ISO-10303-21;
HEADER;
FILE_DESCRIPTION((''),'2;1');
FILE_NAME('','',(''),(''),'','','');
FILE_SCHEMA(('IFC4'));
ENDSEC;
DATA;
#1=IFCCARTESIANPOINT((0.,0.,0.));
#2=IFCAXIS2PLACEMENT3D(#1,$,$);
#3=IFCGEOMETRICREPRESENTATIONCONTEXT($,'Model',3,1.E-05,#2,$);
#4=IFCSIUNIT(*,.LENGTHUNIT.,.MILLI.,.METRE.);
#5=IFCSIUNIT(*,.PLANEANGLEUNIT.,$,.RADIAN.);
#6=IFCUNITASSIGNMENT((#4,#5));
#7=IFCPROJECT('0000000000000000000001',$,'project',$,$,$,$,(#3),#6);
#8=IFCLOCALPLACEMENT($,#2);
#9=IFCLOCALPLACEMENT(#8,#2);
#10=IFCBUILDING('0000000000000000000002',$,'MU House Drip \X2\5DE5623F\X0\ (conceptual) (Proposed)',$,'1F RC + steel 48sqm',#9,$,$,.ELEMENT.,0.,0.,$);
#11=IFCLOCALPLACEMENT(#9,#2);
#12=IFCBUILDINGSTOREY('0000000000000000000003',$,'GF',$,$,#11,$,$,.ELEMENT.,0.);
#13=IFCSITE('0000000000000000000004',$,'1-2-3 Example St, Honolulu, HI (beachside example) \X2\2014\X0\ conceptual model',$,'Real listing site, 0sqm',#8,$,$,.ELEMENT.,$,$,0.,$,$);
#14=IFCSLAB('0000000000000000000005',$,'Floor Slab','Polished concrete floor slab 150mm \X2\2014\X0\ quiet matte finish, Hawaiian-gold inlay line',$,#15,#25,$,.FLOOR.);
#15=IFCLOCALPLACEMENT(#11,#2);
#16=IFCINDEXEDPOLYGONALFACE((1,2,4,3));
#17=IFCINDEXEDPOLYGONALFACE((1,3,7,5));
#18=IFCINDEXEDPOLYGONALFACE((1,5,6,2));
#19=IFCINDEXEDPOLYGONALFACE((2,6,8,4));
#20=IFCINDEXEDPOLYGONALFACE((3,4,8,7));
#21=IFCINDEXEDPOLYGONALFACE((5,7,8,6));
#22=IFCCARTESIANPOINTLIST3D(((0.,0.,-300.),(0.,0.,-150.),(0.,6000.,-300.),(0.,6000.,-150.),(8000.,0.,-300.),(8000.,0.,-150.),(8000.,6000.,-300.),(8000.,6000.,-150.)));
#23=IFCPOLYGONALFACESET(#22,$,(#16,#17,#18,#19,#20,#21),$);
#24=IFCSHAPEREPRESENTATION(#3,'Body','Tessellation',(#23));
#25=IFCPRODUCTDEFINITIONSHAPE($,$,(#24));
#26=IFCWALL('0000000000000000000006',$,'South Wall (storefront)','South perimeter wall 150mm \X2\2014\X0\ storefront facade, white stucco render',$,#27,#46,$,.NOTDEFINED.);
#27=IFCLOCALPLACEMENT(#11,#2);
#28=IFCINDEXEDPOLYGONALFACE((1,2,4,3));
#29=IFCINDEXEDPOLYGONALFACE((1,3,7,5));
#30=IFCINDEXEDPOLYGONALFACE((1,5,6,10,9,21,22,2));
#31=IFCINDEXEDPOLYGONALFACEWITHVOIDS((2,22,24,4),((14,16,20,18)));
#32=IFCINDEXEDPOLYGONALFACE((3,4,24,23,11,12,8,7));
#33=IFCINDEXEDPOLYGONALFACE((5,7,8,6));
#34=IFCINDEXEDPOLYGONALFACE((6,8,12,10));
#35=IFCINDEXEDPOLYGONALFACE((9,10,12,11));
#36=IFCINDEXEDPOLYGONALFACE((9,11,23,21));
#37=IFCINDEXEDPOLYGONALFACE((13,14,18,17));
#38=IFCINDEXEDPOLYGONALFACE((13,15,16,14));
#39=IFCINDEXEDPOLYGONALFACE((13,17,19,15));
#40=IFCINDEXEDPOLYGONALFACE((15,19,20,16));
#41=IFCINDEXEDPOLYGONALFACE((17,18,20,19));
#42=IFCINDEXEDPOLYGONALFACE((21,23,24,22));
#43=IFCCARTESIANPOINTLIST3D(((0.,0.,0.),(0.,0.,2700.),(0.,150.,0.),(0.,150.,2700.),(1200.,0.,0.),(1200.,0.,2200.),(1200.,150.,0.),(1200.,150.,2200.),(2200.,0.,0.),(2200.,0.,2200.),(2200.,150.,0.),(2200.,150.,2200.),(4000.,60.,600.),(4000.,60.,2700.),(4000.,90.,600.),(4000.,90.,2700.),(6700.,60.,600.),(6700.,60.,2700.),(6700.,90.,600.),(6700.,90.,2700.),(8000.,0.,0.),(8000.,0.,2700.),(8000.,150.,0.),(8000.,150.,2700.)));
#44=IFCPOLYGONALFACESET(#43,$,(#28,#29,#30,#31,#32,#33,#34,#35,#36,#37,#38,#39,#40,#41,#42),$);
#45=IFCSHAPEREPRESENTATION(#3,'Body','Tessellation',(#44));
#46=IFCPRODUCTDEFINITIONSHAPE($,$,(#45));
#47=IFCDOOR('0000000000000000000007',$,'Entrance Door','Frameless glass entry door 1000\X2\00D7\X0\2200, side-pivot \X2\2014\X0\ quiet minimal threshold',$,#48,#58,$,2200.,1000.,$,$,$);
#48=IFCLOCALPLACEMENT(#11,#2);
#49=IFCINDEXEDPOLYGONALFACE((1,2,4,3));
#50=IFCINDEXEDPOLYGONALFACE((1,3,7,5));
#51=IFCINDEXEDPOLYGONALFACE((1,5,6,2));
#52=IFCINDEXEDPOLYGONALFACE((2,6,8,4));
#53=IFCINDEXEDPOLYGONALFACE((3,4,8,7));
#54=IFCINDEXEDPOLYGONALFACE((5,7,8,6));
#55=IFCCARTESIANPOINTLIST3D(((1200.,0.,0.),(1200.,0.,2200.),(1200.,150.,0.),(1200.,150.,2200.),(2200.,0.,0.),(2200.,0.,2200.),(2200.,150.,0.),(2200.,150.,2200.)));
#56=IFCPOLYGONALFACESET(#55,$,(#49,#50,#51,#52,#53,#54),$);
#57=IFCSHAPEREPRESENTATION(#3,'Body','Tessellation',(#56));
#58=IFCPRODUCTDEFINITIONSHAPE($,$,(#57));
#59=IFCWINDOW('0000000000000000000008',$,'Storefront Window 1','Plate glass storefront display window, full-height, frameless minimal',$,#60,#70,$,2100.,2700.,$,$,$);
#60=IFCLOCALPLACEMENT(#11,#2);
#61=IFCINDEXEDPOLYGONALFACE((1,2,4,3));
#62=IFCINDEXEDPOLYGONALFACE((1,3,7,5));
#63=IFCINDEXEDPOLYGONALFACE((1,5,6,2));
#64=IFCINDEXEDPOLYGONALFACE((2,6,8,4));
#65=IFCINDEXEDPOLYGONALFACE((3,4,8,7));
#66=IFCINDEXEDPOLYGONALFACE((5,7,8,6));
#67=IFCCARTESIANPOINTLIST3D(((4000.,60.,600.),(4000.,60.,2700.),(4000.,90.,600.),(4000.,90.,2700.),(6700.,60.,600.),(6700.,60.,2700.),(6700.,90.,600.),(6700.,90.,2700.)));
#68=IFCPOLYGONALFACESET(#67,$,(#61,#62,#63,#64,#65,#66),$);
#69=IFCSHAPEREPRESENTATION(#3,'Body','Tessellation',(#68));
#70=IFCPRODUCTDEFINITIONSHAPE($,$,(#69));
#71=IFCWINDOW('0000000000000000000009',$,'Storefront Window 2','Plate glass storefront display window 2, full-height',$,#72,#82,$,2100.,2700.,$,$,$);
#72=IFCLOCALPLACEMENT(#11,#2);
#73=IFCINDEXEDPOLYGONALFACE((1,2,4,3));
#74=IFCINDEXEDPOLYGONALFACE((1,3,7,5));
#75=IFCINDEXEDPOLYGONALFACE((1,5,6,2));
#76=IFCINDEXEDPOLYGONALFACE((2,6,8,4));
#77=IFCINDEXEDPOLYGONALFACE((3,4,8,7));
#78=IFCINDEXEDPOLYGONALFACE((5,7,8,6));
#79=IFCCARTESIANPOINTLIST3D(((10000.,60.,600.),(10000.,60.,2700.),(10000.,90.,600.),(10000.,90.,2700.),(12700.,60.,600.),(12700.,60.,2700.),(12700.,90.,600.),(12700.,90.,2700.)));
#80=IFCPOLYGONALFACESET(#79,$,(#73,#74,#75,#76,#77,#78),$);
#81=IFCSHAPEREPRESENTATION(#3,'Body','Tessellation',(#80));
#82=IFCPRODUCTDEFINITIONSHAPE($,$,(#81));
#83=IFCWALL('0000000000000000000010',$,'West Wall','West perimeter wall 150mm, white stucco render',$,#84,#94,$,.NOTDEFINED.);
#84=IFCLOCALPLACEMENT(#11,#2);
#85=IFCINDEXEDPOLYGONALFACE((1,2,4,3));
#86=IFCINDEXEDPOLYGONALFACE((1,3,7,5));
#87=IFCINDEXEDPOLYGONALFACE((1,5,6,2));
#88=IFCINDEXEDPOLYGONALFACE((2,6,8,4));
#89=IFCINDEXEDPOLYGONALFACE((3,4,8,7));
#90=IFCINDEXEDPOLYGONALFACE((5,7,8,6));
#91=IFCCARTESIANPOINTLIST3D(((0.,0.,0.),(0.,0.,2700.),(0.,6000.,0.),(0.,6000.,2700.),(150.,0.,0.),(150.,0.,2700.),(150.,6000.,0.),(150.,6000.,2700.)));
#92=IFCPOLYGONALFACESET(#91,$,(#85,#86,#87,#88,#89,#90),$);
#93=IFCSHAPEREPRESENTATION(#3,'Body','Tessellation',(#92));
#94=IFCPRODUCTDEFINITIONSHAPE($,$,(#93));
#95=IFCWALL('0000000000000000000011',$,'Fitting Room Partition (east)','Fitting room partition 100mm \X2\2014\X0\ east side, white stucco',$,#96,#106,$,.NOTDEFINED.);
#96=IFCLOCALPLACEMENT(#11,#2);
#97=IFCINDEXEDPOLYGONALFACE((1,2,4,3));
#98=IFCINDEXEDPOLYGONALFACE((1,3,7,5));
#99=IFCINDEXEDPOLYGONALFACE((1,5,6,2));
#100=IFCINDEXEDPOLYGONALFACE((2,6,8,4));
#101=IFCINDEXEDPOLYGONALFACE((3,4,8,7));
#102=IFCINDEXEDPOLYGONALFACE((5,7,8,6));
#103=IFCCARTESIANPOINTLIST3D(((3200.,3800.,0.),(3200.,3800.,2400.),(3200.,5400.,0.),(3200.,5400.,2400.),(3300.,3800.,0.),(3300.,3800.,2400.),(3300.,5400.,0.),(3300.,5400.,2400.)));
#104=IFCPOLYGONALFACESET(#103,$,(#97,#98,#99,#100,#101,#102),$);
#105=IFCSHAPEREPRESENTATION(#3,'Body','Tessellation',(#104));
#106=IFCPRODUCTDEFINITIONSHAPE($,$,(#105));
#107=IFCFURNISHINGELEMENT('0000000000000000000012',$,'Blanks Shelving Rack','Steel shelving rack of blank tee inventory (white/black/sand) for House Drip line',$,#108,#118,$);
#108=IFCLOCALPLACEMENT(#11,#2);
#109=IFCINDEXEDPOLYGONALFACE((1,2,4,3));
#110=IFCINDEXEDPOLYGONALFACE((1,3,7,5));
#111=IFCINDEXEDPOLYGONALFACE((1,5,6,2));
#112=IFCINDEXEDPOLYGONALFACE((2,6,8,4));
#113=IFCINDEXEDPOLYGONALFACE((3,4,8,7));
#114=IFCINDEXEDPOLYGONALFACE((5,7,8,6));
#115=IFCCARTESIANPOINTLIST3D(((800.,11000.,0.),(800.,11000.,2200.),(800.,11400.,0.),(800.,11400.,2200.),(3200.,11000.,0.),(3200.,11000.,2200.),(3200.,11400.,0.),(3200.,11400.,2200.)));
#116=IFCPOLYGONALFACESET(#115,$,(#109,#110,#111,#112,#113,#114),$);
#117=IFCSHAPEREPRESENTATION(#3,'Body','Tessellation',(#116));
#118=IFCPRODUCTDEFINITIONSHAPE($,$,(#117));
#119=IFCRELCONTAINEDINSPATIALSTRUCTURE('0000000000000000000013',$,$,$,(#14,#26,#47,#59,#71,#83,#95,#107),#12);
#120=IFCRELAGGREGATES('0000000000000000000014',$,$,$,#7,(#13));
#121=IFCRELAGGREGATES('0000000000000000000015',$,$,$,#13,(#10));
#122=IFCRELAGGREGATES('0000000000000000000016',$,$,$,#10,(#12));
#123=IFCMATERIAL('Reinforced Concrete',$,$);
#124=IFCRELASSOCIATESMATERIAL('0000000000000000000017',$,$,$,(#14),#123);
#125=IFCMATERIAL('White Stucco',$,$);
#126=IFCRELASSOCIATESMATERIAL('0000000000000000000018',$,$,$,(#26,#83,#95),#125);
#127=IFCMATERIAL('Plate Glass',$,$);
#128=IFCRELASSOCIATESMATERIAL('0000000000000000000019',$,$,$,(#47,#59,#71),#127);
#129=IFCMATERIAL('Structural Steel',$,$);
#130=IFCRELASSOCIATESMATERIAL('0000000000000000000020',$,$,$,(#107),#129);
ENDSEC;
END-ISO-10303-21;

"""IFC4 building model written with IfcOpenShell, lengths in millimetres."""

from ifc_helpers import new_model, si_unit, frame, frame_2d, origin, place, context, project, spatial, rectangle, extrude, material, element, fill, save


model = new_model("IFC4")

# Units and contexts
model_context = context("Model", 3, precision=1e-05, world=origin())
ifc_project = project(units=[si_unit("LENGTHUNIT", "METRE", prefix="MILLI"), si_unit("PLANEANGLEUNIT", "RADIAN")], contexts=[model_context])

# Site, building, storey
site_placement = place(None, origin())
site = spatial("IfcSite", under=ifc_project, at=site_placement, Name="1-2-3 Example St, Honolulu, HI (beachside example) — conceptual model", ObjectType="Real listing site, 0sqm", CompositionType="ELEMENT", RefElevation=0.0)
building_placement = place(site_placement, origin())
building = spatial("IfcBuilding", under=site, at=building_placement, Name="MU House Drip 工房 (conceptual) (Proposed)", ObjectType="1F RC + steel 48sqm", CompositionType="ELEMENT", ElevationOfRefHeight=0.0, ElevationOfTerrain=0.0)
storey_placement = place(building_placement, origin())
storey = spatial("IfcBuildingStorey", under=building, at=storey_placement, Name="GF", CompositionType="ELEMENT", Elevation=0.0)

# Slab
ifc_material_1 = material(Name="Reinforced Concrete")
slab_1_placement = place(storey_placement, frame((0.0, 0.0, -150.0)))
element("IfcSlab", 1, at=slab_1_placement, inside=storey, material=ifc_material_1, Name="Floor Slab", Description="Polished concrete floor slab 150mm — quiet matte finish, Hawaiian-gold inlay line", PredefinedType="FLOOR", context=model_context, shape_type="SweptSolid", body=[
    extrude(rectangle(XDim=8000.0, YDim=6000.0, at=frame_2d((4000.0, 3000.0))), frame((0.0, 0.0, -150.0)), (0.0, 0.0, 1.0), 150.0),
])

# Wall, openings, door, windows
ifc_material_2 = material(Name="White Stucco")
wall_1_placement = place(storey_placement, origin())
wall_1 = element("IfcWall", 2, at=wall_1_placement, inside=storey, material=ifc_material_2, Name="South Wall (storefront)", Description="South perimeter wall 150mm — storefront facade, white stucco render", PredefinedType="NOTDEFINED", context=model_context, shape_type="SweptSolid", body=[
    extrude(rectangle(XDim=8000.0, YDim=150.0, at=frame_2d((4000.0, 75.0))), origin(), (0.0, 0.0, 1.0), 2700.0),
])
opening_1_placement = place(storey_placement, frame((600.0, 0.0, 0.0)))
opening_1 = element("IfcOpeningElement", 3, at=opening_1_placement, cuts=wall_1, PredefinedType="NOTDEFINED", context=model_context, shape_type="SweptSolid", body=[
    extrude(rectangle(XDim=1000.0, YDim=150.0, at=frame_2d((500.0, 75.0))), frame((600.0, 0.0, 0.0)), (0.0, 0.0, 1.0), 2200.0),
])
opening_2_placement = place(storey_placement, frame((2000.0, 30.0, 300.0)))
opening_2 = element("IfcOpeningElement", 4, at=opening_2_placement, cuts=wall_1, PredefinedType="NOTDEFINED", context=model_context, shape_type="SweptSolid", body=[
    extrude(rectangle(XDim=2700.0, YDim=30.0, at=frame_2d((1350.0, 15.0))), frame((2000.0, 30.0, 300.0)), (0.0, 0.0, 1.0), 2100.0),
])
opening_3_placement = place(storey_placement, frame((5000.0, 30.0, 300.0)))
opening_3 = element("IfcOpeningElement", 5, at=opening_3_placement, cuts=wall_1, PredefinedType="NOTDEFINED", context=model_context, shape_type="SweptSolid", body=[
    extrude(rectangle(XDim=2700.0, YDim=30.0, at=frame_2d((1350.0, 15.0))), frame((5000.0, 30.0, 300.0)), (0.0, 0.0, 1.0), 2100.0),
])
ifc_material_3 = material(Name="Plate Glass")
door_1_placement = place(storey_placement, frame((600.0, 0.0, 0.0)))
door_1 = element("IfcDoor", 6, at=door_1_placement, inside=storey, material=ifc_material_3, Name="Entrance Door", Description="Frameless glass entry door 1000×2200, side-pivot — quiet minimal threshold", OverallHeight=2200.0, OverallWidth=1000.0, context=model_context, shape_type="SweptSolid", body=[
    extrude(rectangle(XDim=1000.0, YDim=150.0, at=frame_2d((500.0, 75.0))), frame((600.0, 0.0, 0.0)), (0.0, 0.0, 1.0), 2200.0),
])
fill(opening_1, door_1)
window_1_placement = place(storey_placement, frame((2000.0, 30.0, 300.0)))
window_1 = element("IfcWindow", 7, at=window_1_placement, inside=storey, material=ifc_material_3, Name="Storefront Window 1", Description="Plate glass storefront display window, full-height, frameless minimal", OverallHeight=2100.0, OverallWidth=2700.0, context=model_context, shape_type="SweptSolid", body=[
    extrude(rectangle(XDim=2700.0, YDim=30.0, at=frame_2d((1350.0, 15.0))), frame((2000.0, 30.0, 300.0)), (0.0, 0.0, 1.0), 2100.0),
])
fill(opening_2, window_1)
window_2_placement = place(storey_placement, frame((5000.0, 30.0, 300.0)))
window_2 = element("IfcWindow", 8, at=window_2_placement, inside=storey, material=ifc_material_3, Name="Storefront Window 2", Description="Plate glass storefront display window 2, full-height", OverallHeight=2100.0, OverallWidth=2700.0, context=model_context, shape_type="SweptSolid", body=[
    extrude(rectangle(XDim=2700.0, YDim=30.0, at=frame_2d((1350.0, 15.0))), frame((5000.0, 30.0, 300.0)), (0.0, 0.0, 1.0), 2100.0),
])
fill(opening_3, window_2)

# Walls
wall_2_placement = place(storey_placement, origin())
element("IfcWall", 9, at=wall_2_placement, inside=storey, material=ifc_material_2, Name="West Wall", Description="West perimeter wall 150mm, white stucco render", PredefinedType="NOTDEFINED", context=model_context, shape_type="SweptSolid", body=[
    extrude(rectangle(XDim=150.0, YDim=6000.0, at=frame_2d((75.0, 3000.0))), origin(), (0.0, 0.0, 1.0), 2700.0),
])
wall_3_placement = place(storey_placement, frame((1600.0, 1900.0, 0.0)))
element("IfcWall", 10, at=wall_3_placement, inside=storey, material=ifc_material_2, Name="Fitting Room Partition (east)", Description="Fitting room partition 100mm — east side, white stucco", PredefinedType="NOTDEFINED", context=model_context, shape_type="SweptSolid", body=[
    extrude(rectangle(XDim=100.0, YDim=1600.0, at=frame_2d((50.0, 800.0))), frame((1600.0, 1900.0, 0.0)), (0.0, 0.0, 1.0), 2400.0),
])

# Furnishing element
ifc_material_4 = material(Name="Structural Steel")
furnishing_1_placement = place(storey_placement, frame((400.0, 5500.0, 0.0)))
element("IfcFurnishingElement", 11, at=furnishing_1_placement, inside=storey, material=ifc_material_4, Name="Blanks Shelving Rack", Description="Steel shelving rack of blank tee inventory (white/black/sand) for House Drip line", context=model_context, shape_type="SweptSolid", body=[
    extrude(rectangle(XDim=2400.0, YDim=400.0, at=frame_2d((1200.0, 200.0))), frame((400.0, 5500.0, 0.0)), (0.0, 0.0, 1.0), 2200.0),
])

save(model, "model.ifc")
